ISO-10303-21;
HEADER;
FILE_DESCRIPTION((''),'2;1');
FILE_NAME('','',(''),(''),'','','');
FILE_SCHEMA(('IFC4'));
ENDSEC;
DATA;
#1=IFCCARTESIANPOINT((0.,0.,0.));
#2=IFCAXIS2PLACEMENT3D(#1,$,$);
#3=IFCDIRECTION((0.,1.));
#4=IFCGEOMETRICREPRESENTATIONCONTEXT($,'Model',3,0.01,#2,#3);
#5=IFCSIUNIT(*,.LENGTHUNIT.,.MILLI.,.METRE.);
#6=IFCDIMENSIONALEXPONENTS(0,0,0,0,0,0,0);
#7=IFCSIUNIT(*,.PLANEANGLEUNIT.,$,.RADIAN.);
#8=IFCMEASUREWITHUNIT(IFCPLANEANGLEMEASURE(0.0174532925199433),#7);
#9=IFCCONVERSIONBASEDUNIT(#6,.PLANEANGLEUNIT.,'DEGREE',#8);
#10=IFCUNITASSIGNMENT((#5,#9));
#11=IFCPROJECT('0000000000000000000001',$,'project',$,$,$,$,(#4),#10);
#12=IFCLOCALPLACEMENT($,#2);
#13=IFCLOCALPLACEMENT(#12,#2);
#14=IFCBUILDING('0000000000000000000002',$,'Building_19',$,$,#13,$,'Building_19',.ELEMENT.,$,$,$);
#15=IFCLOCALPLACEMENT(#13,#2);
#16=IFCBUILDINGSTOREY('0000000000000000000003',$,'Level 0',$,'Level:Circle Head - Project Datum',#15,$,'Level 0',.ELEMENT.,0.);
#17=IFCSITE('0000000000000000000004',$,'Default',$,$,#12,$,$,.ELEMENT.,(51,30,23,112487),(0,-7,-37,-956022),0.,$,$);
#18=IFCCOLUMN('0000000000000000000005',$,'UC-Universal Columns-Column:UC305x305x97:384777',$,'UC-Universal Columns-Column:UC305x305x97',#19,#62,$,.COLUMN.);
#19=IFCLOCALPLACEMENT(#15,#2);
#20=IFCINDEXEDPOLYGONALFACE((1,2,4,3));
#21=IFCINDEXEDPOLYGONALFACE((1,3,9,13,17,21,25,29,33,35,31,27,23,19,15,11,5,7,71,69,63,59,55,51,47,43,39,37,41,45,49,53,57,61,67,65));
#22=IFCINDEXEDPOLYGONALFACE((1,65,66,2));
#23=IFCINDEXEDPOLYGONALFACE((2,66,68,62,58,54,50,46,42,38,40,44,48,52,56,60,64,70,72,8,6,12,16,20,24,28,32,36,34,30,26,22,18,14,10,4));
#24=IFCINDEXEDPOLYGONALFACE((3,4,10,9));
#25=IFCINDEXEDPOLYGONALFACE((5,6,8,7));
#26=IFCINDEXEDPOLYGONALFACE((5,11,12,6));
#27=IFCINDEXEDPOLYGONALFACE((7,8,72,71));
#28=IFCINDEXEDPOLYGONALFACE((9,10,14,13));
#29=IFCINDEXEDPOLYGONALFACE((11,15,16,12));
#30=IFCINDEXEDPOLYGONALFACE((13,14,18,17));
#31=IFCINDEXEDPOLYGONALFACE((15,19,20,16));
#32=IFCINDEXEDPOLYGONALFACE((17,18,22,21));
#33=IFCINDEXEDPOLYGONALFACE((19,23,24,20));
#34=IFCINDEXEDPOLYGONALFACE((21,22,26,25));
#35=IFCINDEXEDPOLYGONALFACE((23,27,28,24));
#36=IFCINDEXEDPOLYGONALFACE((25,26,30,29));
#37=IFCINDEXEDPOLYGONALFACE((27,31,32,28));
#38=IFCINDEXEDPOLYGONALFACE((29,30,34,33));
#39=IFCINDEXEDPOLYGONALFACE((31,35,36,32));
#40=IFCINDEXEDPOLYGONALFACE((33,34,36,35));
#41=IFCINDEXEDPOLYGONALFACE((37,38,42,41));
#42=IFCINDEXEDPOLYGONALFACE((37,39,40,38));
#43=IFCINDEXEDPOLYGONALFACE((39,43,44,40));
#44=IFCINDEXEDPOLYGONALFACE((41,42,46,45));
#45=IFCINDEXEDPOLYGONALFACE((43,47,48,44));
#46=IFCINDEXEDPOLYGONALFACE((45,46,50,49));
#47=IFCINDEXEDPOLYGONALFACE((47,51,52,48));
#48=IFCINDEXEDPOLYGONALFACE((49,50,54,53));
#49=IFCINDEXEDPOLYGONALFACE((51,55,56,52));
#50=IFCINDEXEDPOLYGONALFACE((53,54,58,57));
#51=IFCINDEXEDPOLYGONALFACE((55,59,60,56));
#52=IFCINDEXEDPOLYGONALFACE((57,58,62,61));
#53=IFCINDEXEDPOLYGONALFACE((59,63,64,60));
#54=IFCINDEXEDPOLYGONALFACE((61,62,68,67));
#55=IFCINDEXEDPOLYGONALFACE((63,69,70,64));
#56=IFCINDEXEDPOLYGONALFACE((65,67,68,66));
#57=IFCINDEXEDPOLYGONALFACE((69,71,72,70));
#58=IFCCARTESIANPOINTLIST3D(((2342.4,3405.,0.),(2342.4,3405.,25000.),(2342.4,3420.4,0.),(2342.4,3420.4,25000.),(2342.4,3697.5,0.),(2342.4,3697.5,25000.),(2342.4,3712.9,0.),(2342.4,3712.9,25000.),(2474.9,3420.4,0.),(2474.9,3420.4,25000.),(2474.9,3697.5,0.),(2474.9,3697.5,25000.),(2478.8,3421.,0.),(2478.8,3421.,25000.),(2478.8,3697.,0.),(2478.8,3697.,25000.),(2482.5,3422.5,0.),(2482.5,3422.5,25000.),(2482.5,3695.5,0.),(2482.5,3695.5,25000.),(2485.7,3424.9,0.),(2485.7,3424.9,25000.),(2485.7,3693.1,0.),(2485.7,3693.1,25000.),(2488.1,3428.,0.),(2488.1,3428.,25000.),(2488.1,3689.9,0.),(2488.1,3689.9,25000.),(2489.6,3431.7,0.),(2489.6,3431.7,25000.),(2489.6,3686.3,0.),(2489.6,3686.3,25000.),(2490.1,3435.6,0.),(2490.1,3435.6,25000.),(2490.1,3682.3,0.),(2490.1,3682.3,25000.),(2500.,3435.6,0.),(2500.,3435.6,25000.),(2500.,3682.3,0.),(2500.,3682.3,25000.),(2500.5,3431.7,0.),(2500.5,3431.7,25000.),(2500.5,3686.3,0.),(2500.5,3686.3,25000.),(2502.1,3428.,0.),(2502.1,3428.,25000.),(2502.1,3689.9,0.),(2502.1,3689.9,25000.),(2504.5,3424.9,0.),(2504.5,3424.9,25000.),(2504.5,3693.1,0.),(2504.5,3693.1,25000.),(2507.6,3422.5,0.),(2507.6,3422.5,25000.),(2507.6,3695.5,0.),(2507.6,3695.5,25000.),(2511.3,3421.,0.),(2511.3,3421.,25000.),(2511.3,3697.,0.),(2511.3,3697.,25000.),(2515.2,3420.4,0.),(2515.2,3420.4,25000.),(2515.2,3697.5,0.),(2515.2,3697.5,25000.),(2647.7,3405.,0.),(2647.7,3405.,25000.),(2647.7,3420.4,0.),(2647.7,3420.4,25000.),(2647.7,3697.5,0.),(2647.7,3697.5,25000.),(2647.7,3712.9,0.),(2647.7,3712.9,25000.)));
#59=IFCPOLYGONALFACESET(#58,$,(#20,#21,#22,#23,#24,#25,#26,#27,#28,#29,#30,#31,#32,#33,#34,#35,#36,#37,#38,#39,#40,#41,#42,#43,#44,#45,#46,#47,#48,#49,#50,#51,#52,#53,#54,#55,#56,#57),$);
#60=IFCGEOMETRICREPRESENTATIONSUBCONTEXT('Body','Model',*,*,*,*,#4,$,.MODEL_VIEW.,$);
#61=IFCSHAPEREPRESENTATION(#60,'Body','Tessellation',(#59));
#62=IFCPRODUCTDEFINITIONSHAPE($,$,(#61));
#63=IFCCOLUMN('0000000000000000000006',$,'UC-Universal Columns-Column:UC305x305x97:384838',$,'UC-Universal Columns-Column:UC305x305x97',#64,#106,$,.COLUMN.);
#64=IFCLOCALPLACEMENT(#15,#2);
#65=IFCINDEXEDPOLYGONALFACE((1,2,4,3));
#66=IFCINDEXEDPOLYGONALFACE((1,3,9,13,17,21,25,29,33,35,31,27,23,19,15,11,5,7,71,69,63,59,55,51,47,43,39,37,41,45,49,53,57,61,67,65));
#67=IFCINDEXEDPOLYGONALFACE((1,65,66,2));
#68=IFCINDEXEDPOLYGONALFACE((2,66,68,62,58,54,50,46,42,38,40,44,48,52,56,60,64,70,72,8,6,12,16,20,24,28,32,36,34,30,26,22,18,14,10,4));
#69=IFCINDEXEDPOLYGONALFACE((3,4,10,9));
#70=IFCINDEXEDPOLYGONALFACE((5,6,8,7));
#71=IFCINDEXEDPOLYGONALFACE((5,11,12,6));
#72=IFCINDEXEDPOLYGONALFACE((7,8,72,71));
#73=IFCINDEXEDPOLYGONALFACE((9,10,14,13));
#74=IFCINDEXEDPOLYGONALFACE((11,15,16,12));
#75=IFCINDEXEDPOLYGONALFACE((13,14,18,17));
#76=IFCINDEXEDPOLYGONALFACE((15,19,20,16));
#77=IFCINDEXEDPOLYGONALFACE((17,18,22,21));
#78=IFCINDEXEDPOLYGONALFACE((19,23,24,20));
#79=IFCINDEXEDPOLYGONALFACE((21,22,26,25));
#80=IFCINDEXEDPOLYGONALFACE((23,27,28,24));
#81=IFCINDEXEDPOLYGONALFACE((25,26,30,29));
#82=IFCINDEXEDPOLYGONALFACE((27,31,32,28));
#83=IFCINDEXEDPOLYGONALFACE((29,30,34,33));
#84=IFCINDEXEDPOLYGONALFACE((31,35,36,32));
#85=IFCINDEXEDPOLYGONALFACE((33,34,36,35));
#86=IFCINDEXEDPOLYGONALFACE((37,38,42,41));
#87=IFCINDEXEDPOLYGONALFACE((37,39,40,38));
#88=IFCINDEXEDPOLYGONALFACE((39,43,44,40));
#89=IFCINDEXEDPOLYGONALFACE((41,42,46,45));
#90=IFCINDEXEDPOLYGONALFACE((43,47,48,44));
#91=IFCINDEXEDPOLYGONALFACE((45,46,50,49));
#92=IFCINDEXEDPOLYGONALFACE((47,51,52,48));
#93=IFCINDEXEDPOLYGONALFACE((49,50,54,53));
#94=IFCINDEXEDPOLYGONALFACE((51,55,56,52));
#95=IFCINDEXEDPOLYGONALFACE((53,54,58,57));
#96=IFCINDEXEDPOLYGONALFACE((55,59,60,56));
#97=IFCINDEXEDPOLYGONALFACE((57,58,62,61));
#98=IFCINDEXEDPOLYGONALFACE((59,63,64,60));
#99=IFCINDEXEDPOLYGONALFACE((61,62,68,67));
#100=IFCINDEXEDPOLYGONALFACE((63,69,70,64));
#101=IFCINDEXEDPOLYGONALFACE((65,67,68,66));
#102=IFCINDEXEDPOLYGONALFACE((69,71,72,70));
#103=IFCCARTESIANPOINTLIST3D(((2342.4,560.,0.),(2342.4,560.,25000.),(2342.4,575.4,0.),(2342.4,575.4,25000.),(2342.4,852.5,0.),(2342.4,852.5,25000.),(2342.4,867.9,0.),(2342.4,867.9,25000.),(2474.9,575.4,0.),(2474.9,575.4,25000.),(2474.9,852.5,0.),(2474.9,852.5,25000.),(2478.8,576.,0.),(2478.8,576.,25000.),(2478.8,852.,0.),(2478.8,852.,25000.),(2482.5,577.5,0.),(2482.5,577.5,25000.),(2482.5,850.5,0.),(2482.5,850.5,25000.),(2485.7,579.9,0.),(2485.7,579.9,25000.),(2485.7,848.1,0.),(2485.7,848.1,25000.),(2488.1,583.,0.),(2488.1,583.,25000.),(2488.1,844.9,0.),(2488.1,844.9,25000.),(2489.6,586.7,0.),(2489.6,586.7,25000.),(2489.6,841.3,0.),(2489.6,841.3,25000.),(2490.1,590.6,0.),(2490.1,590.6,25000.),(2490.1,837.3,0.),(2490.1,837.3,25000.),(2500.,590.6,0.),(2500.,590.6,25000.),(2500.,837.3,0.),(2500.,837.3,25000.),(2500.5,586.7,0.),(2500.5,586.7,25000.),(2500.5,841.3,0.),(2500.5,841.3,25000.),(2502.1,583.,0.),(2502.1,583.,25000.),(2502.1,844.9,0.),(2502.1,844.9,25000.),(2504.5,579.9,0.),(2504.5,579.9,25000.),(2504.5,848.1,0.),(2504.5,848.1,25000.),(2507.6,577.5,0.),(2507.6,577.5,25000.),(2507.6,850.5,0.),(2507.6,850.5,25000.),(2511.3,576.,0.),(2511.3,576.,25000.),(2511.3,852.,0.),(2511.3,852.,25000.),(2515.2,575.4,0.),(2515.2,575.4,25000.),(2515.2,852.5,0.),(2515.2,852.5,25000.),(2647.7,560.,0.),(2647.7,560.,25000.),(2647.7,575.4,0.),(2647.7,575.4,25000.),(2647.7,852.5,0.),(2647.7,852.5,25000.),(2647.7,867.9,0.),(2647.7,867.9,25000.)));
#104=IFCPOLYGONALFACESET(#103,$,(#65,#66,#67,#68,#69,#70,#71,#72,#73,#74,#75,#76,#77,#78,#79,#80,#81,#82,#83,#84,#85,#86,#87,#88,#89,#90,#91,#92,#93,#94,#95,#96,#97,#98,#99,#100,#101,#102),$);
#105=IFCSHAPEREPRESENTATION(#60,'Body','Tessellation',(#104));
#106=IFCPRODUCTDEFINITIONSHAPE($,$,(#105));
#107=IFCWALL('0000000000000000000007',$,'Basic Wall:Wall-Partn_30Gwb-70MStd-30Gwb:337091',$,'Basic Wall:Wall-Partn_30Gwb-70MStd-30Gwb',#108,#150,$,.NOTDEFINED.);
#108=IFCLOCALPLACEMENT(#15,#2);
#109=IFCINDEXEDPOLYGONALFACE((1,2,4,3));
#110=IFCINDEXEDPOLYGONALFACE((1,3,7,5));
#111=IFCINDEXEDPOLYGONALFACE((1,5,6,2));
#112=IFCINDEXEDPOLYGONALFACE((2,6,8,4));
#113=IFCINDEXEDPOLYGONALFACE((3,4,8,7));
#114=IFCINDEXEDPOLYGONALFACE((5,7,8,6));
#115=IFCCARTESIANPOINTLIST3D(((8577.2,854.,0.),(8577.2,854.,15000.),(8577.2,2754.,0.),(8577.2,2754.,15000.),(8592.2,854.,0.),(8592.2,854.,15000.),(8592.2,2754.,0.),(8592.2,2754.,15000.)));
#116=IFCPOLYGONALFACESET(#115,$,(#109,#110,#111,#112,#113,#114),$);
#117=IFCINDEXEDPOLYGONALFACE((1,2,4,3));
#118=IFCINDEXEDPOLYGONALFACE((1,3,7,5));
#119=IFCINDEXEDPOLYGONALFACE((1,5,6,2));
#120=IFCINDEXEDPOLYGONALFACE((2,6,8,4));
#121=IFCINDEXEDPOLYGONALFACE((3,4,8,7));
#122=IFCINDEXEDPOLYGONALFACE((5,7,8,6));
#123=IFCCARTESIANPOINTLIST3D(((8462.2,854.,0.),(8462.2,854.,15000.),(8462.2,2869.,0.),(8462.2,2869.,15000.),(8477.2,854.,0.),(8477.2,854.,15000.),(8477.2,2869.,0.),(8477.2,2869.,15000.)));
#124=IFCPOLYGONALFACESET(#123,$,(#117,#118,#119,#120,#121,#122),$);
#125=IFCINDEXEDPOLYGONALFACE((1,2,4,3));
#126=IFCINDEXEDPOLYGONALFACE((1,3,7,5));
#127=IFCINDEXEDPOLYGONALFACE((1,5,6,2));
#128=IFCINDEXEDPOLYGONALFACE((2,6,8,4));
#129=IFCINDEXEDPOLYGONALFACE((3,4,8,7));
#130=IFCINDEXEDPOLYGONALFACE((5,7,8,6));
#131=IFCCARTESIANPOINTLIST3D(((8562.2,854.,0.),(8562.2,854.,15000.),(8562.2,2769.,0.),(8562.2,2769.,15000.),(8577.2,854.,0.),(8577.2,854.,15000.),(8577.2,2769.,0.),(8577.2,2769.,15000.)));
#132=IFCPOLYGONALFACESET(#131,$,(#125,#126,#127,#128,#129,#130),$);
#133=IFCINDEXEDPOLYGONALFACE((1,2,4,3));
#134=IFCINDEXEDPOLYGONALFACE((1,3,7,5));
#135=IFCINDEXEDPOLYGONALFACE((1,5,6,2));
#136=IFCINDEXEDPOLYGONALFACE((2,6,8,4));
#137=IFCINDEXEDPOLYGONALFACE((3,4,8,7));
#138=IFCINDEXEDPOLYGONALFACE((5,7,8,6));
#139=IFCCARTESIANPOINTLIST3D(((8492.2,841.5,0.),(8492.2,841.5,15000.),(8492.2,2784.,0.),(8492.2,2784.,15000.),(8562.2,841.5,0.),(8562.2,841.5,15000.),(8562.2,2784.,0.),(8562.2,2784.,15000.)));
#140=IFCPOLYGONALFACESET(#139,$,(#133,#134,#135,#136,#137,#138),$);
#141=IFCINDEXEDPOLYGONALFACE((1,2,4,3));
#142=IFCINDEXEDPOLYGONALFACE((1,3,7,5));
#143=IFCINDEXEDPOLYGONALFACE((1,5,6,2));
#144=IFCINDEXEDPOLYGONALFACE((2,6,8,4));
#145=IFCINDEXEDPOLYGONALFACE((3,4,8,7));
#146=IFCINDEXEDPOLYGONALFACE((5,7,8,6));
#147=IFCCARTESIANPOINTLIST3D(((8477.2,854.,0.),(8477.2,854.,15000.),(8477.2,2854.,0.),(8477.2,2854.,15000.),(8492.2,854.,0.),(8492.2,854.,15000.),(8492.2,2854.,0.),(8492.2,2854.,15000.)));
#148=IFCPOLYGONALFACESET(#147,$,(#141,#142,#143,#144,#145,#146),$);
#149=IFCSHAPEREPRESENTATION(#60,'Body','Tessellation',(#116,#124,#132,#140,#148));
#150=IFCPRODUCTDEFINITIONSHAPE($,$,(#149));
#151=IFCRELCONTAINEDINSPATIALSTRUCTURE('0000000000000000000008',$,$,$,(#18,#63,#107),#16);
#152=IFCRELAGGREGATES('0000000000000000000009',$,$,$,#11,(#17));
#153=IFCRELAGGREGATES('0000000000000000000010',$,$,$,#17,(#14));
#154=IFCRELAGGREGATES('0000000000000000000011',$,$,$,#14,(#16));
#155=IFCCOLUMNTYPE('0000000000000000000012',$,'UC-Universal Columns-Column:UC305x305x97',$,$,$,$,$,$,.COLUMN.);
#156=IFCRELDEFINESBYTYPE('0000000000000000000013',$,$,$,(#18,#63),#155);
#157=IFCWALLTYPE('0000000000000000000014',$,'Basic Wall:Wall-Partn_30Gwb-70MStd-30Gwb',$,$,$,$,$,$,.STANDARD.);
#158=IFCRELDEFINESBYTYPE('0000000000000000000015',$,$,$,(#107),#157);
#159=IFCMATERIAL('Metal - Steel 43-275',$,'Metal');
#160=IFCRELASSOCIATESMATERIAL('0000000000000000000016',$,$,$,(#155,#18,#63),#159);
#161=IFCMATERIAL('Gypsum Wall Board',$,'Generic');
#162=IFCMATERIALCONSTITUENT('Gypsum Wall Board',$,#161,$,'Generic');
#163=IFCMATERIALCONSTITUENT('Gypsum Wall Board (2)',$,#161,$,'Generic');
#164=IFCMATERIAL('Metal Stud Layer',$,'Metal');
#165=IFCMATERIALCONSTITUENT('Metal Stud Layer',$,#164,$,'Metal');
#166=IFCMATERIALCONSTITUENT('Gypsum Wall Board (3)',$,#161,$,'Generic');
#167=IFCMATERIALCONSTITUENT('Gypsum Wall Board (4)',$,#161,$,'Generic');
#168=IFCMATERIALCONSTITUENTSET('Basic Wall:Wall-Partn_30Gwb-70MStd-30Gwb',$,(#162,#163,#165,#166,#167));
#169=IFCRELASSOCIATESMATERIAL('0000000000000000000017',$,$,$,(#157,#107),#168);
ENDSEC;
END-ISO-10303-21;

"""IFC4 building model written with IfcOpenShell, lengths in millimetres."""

from ifc_helpers import new_model, entity, si_unit, converted_unit, direction, frame, origin, place, context, subcontext, project, spatial, line, arc, indexed_curve, outline, extrude, source, transform, mapped, material, constituent, constituent_set, type_object, type_shapes, element, save


model = new_model("IFC4")

# Units and contexts
model_context = context("Model", 3, precision=0.01, world=origin(), true_north=direction((0.0, 1.0)))
body_context = subcontext(model_context, "Body", "Model", "MODEL_VIEW")
ifc_project = project(units=[si_unit("LENGTHUNIT", "METRE", prefix="MILLI"), converted_unit("PLANEANGLEUNIT", "DEGREE", entity("IfcPlaneAngleMeasure", 0.0174532925199433), si_unit("PLANEANGLEUNIT", "RADIAN"), dimensions=[0, 0, 0, 0, 0, 0, 0])], contexts=[model_context])

# Site, building, storey
site_placement = place(None, origin())
site = spatial("IfcSite", under=ifc_project, at=site_placement, Name="Default", CompositionType="ELEMENT", RefLatitude=(51, 30, 23, 112487), RefLongitude=(0, -7, -37, -956022), RefElevation=0.0)
building_placement = place(site_placement, origin())
building = spatial("IfcBuilding", under=site, at=building_placement, Name="Building_19", LongName="Building_19", CompositionType="ELEMENT")
storey_placement = place(building_placement, origin())
storey = spatial("IfcBuildingStorey", under=building, at=storey_placement, Name="Level 0", ObjectType="Level:Circle Head - Project Datum", LongName="Level 0", CompositionType="ELEMENT", Elevation=0.0)

# Columns
ifc_material_1 = material(Name="Metal - Steel 43-275", Category="Metal")
column_type = type_object("IfcColumnType", Name="UC-Universal Columns-Column:UC305x305x97", PredefinedType="COLUMN", material=ifc_material_1)
shared_shape_1 = source(origin(), body_context, "Body", "SweptSolid", [
    extrude(outline(indexed_curve([(-152.7, -153.9), (152.7, -153.9), (152.7, -138.6), (20.2, -138.6), (9.4, -134.1), (4.9, -123.3), (4.9, 123.3), (9.4, 134.1), (20.1, 138.6), (152.7, 138.6), (152.7, 153.9), (-152.7, 153.9), (-152.7, 138.6), (-20.2, 138.6), (-9.4, 134.1), (-5.0, 123.3), (-5.0, -123.3), (-9.4, -134.1), (-20.2, -138.6), (-152.7, -138.6)], segments=[line(1, 2, 3, 4), arc(4, 5, 6), line(6, 7), arc(7, 8, 9), line(9, 10, 11, 12, 13, 14), arc(14, 15, 16), line(16, 17), arc(17, 18, 19), line(19, 20, 1)], self_intersect=False)), frame((0.0, 0.0, 0.0), z_axis=(0.0, 0.0, 1.0), x_axis=(-1.0, 0.0, 0.0)), (0.0, 0.0, 1.0), 25000.0),
])
type_shapes(column_type, [shared_shape_1])
for number, where, name in (
    (1, (2495.1, 3559.0, 0.0), "UC-Universal Columns-Column:UC305x305x97:384777"),
    (2, (2495.1, 714.0, 0.0), "UC-Universal Columns-Column:UC305x305x97:384838"),
):
    element("IfcColumn", number, at=place(storey_placement, frame(where)), inside=storey, type_object=column_type, material=ifc_material_1, Name=name, ObjectType="UC-Universal Columns-Column:UC305x305x97", PredefinedType="COLUMN", context=body_context, shape_type="MappedRepresentation", body=[
        mapped(shared_shape_1, transform((0.0, 0.0, 0.0), scale=1.0)),
    ])

# Wall
ifc_material_2 = material(Name="Gypsum Wall Board", Category="Generic")
ifc_constituent_1 = constituent(ifc_material_2, Name="Gypsum Wall Board", Category="Generic")
ifc_constituent_2 = constituent(ifc_material_2, Name="Gypsum Wall Board (2)", Category="Generic")
ifc_material_3 = material(Name="Metal Stud Layer", Category="Metal")
ifc_constituent_3 = constituent(ifc_material_3, Name="Metal Stud Layer", Category="Metal")
ifc_constituent_4 = constituent(ifc_material_2, Name="Gypsum Wall Board (3)", Category="Generic")
ifc_constituent_5 = constituent(ifc_material_2, Name="Gypsum Wall Board (4)", Category="Generic")
ifc_constituent_set_1 = constituent_set(constituents=[ifc_constituent_1, ifc_constituent_2, ifc_constituent_3, ifc_constituent_4, ifc_constituent_5], Name="Basic Wall:Wall-Partn_30Gwb-70MStd-30Gwb")
wall_type_1 = type_object("IfcWallType", Name="Basic Wall:Wall-Partn_30Gwb-70MStd-30Gwb", PredefinedType="STANDARD", material=ifc_constituent_set_1)
wall_1_placement = place(storey_placement, frame((8527.2, 2754.0, 0.0), z_axis=(0.0, 0.0, 1.0), x_axis=(0.0, -1.0, 0.0)))
element("IfcWall", 3, at=wall_1_placement, inside=storey, type_object=wall_type_1, material=ifc_constituent_set_1, Name="Basic Wall:Wall-Partn_30Gwb-70MStd-30Gwb:337091", ObjectType="Basic Wall:Wall-Partn_30Gwb-70MStd-30Gwb", PredefinedType="NOTDEFINED", context=body_context, shape_type="SweptSolid", body=[
    extrude(outline(indexed_curve([(-7.5, -950.0), (7.5, -950.0), (7.5, 950.0), (-7.5, 950.0), (-7.5, -950.0)], self_intersect=False)), frame((950.0, 57.5, 0.0), z_axis=(0.0, 0.0, 1.0), x_axis=(0.0, -1.0, 0.0)), (0.0, 0.0, 1.0), 15000.0),
    extrude(outline(indexed_curve([(-7.5, -1007.5), (7.5, -1007.5), (7.5, 1007.5), (-7.5, 1007.5), (-7.5, -1007.5)], self_intersect=False)), frame((892.5, -57.5, 0.0), z_axis=(0.0, 0.0, 1.0), x_axis=(0.0, 1.0, 0.0)), (0.0, 0.0, 1.0), 15000.0),
    extrude(outline(indexed_curve([(-957.5, -7.5), (957.5, -7.5), (957.5, 7.5), (-957.5, 7.5), (-957.5, -7.5)], self_intersect=False)), frame((942.5, 42.5, 0.0)), (0.0, 0.0, 1.0), 15000.0),
    extrude(outline(indexed_curve([(-971.2, -35.0), (971.2, -35.0), (971.2, 35.0), (-971.2, 35.0), (-971.2, -35.0)], self_intersect=False)), frame((941.2, 0.0, 0.0)), (0.0, 0.0, 1.0), 15000.0),
    extrude(outline(indexed_curve([(-1000.0, -7.5), (1000.0, -7.5), (1000.0, 7.5), (-1000.0, 7.5), (-1000.0, -7.5)], self_intersect=False)), frame((900.0, -42.5, 0.0)), (0.0, 0.0, 1.0), 15000.0),
])

save(model, "model.ifc")
